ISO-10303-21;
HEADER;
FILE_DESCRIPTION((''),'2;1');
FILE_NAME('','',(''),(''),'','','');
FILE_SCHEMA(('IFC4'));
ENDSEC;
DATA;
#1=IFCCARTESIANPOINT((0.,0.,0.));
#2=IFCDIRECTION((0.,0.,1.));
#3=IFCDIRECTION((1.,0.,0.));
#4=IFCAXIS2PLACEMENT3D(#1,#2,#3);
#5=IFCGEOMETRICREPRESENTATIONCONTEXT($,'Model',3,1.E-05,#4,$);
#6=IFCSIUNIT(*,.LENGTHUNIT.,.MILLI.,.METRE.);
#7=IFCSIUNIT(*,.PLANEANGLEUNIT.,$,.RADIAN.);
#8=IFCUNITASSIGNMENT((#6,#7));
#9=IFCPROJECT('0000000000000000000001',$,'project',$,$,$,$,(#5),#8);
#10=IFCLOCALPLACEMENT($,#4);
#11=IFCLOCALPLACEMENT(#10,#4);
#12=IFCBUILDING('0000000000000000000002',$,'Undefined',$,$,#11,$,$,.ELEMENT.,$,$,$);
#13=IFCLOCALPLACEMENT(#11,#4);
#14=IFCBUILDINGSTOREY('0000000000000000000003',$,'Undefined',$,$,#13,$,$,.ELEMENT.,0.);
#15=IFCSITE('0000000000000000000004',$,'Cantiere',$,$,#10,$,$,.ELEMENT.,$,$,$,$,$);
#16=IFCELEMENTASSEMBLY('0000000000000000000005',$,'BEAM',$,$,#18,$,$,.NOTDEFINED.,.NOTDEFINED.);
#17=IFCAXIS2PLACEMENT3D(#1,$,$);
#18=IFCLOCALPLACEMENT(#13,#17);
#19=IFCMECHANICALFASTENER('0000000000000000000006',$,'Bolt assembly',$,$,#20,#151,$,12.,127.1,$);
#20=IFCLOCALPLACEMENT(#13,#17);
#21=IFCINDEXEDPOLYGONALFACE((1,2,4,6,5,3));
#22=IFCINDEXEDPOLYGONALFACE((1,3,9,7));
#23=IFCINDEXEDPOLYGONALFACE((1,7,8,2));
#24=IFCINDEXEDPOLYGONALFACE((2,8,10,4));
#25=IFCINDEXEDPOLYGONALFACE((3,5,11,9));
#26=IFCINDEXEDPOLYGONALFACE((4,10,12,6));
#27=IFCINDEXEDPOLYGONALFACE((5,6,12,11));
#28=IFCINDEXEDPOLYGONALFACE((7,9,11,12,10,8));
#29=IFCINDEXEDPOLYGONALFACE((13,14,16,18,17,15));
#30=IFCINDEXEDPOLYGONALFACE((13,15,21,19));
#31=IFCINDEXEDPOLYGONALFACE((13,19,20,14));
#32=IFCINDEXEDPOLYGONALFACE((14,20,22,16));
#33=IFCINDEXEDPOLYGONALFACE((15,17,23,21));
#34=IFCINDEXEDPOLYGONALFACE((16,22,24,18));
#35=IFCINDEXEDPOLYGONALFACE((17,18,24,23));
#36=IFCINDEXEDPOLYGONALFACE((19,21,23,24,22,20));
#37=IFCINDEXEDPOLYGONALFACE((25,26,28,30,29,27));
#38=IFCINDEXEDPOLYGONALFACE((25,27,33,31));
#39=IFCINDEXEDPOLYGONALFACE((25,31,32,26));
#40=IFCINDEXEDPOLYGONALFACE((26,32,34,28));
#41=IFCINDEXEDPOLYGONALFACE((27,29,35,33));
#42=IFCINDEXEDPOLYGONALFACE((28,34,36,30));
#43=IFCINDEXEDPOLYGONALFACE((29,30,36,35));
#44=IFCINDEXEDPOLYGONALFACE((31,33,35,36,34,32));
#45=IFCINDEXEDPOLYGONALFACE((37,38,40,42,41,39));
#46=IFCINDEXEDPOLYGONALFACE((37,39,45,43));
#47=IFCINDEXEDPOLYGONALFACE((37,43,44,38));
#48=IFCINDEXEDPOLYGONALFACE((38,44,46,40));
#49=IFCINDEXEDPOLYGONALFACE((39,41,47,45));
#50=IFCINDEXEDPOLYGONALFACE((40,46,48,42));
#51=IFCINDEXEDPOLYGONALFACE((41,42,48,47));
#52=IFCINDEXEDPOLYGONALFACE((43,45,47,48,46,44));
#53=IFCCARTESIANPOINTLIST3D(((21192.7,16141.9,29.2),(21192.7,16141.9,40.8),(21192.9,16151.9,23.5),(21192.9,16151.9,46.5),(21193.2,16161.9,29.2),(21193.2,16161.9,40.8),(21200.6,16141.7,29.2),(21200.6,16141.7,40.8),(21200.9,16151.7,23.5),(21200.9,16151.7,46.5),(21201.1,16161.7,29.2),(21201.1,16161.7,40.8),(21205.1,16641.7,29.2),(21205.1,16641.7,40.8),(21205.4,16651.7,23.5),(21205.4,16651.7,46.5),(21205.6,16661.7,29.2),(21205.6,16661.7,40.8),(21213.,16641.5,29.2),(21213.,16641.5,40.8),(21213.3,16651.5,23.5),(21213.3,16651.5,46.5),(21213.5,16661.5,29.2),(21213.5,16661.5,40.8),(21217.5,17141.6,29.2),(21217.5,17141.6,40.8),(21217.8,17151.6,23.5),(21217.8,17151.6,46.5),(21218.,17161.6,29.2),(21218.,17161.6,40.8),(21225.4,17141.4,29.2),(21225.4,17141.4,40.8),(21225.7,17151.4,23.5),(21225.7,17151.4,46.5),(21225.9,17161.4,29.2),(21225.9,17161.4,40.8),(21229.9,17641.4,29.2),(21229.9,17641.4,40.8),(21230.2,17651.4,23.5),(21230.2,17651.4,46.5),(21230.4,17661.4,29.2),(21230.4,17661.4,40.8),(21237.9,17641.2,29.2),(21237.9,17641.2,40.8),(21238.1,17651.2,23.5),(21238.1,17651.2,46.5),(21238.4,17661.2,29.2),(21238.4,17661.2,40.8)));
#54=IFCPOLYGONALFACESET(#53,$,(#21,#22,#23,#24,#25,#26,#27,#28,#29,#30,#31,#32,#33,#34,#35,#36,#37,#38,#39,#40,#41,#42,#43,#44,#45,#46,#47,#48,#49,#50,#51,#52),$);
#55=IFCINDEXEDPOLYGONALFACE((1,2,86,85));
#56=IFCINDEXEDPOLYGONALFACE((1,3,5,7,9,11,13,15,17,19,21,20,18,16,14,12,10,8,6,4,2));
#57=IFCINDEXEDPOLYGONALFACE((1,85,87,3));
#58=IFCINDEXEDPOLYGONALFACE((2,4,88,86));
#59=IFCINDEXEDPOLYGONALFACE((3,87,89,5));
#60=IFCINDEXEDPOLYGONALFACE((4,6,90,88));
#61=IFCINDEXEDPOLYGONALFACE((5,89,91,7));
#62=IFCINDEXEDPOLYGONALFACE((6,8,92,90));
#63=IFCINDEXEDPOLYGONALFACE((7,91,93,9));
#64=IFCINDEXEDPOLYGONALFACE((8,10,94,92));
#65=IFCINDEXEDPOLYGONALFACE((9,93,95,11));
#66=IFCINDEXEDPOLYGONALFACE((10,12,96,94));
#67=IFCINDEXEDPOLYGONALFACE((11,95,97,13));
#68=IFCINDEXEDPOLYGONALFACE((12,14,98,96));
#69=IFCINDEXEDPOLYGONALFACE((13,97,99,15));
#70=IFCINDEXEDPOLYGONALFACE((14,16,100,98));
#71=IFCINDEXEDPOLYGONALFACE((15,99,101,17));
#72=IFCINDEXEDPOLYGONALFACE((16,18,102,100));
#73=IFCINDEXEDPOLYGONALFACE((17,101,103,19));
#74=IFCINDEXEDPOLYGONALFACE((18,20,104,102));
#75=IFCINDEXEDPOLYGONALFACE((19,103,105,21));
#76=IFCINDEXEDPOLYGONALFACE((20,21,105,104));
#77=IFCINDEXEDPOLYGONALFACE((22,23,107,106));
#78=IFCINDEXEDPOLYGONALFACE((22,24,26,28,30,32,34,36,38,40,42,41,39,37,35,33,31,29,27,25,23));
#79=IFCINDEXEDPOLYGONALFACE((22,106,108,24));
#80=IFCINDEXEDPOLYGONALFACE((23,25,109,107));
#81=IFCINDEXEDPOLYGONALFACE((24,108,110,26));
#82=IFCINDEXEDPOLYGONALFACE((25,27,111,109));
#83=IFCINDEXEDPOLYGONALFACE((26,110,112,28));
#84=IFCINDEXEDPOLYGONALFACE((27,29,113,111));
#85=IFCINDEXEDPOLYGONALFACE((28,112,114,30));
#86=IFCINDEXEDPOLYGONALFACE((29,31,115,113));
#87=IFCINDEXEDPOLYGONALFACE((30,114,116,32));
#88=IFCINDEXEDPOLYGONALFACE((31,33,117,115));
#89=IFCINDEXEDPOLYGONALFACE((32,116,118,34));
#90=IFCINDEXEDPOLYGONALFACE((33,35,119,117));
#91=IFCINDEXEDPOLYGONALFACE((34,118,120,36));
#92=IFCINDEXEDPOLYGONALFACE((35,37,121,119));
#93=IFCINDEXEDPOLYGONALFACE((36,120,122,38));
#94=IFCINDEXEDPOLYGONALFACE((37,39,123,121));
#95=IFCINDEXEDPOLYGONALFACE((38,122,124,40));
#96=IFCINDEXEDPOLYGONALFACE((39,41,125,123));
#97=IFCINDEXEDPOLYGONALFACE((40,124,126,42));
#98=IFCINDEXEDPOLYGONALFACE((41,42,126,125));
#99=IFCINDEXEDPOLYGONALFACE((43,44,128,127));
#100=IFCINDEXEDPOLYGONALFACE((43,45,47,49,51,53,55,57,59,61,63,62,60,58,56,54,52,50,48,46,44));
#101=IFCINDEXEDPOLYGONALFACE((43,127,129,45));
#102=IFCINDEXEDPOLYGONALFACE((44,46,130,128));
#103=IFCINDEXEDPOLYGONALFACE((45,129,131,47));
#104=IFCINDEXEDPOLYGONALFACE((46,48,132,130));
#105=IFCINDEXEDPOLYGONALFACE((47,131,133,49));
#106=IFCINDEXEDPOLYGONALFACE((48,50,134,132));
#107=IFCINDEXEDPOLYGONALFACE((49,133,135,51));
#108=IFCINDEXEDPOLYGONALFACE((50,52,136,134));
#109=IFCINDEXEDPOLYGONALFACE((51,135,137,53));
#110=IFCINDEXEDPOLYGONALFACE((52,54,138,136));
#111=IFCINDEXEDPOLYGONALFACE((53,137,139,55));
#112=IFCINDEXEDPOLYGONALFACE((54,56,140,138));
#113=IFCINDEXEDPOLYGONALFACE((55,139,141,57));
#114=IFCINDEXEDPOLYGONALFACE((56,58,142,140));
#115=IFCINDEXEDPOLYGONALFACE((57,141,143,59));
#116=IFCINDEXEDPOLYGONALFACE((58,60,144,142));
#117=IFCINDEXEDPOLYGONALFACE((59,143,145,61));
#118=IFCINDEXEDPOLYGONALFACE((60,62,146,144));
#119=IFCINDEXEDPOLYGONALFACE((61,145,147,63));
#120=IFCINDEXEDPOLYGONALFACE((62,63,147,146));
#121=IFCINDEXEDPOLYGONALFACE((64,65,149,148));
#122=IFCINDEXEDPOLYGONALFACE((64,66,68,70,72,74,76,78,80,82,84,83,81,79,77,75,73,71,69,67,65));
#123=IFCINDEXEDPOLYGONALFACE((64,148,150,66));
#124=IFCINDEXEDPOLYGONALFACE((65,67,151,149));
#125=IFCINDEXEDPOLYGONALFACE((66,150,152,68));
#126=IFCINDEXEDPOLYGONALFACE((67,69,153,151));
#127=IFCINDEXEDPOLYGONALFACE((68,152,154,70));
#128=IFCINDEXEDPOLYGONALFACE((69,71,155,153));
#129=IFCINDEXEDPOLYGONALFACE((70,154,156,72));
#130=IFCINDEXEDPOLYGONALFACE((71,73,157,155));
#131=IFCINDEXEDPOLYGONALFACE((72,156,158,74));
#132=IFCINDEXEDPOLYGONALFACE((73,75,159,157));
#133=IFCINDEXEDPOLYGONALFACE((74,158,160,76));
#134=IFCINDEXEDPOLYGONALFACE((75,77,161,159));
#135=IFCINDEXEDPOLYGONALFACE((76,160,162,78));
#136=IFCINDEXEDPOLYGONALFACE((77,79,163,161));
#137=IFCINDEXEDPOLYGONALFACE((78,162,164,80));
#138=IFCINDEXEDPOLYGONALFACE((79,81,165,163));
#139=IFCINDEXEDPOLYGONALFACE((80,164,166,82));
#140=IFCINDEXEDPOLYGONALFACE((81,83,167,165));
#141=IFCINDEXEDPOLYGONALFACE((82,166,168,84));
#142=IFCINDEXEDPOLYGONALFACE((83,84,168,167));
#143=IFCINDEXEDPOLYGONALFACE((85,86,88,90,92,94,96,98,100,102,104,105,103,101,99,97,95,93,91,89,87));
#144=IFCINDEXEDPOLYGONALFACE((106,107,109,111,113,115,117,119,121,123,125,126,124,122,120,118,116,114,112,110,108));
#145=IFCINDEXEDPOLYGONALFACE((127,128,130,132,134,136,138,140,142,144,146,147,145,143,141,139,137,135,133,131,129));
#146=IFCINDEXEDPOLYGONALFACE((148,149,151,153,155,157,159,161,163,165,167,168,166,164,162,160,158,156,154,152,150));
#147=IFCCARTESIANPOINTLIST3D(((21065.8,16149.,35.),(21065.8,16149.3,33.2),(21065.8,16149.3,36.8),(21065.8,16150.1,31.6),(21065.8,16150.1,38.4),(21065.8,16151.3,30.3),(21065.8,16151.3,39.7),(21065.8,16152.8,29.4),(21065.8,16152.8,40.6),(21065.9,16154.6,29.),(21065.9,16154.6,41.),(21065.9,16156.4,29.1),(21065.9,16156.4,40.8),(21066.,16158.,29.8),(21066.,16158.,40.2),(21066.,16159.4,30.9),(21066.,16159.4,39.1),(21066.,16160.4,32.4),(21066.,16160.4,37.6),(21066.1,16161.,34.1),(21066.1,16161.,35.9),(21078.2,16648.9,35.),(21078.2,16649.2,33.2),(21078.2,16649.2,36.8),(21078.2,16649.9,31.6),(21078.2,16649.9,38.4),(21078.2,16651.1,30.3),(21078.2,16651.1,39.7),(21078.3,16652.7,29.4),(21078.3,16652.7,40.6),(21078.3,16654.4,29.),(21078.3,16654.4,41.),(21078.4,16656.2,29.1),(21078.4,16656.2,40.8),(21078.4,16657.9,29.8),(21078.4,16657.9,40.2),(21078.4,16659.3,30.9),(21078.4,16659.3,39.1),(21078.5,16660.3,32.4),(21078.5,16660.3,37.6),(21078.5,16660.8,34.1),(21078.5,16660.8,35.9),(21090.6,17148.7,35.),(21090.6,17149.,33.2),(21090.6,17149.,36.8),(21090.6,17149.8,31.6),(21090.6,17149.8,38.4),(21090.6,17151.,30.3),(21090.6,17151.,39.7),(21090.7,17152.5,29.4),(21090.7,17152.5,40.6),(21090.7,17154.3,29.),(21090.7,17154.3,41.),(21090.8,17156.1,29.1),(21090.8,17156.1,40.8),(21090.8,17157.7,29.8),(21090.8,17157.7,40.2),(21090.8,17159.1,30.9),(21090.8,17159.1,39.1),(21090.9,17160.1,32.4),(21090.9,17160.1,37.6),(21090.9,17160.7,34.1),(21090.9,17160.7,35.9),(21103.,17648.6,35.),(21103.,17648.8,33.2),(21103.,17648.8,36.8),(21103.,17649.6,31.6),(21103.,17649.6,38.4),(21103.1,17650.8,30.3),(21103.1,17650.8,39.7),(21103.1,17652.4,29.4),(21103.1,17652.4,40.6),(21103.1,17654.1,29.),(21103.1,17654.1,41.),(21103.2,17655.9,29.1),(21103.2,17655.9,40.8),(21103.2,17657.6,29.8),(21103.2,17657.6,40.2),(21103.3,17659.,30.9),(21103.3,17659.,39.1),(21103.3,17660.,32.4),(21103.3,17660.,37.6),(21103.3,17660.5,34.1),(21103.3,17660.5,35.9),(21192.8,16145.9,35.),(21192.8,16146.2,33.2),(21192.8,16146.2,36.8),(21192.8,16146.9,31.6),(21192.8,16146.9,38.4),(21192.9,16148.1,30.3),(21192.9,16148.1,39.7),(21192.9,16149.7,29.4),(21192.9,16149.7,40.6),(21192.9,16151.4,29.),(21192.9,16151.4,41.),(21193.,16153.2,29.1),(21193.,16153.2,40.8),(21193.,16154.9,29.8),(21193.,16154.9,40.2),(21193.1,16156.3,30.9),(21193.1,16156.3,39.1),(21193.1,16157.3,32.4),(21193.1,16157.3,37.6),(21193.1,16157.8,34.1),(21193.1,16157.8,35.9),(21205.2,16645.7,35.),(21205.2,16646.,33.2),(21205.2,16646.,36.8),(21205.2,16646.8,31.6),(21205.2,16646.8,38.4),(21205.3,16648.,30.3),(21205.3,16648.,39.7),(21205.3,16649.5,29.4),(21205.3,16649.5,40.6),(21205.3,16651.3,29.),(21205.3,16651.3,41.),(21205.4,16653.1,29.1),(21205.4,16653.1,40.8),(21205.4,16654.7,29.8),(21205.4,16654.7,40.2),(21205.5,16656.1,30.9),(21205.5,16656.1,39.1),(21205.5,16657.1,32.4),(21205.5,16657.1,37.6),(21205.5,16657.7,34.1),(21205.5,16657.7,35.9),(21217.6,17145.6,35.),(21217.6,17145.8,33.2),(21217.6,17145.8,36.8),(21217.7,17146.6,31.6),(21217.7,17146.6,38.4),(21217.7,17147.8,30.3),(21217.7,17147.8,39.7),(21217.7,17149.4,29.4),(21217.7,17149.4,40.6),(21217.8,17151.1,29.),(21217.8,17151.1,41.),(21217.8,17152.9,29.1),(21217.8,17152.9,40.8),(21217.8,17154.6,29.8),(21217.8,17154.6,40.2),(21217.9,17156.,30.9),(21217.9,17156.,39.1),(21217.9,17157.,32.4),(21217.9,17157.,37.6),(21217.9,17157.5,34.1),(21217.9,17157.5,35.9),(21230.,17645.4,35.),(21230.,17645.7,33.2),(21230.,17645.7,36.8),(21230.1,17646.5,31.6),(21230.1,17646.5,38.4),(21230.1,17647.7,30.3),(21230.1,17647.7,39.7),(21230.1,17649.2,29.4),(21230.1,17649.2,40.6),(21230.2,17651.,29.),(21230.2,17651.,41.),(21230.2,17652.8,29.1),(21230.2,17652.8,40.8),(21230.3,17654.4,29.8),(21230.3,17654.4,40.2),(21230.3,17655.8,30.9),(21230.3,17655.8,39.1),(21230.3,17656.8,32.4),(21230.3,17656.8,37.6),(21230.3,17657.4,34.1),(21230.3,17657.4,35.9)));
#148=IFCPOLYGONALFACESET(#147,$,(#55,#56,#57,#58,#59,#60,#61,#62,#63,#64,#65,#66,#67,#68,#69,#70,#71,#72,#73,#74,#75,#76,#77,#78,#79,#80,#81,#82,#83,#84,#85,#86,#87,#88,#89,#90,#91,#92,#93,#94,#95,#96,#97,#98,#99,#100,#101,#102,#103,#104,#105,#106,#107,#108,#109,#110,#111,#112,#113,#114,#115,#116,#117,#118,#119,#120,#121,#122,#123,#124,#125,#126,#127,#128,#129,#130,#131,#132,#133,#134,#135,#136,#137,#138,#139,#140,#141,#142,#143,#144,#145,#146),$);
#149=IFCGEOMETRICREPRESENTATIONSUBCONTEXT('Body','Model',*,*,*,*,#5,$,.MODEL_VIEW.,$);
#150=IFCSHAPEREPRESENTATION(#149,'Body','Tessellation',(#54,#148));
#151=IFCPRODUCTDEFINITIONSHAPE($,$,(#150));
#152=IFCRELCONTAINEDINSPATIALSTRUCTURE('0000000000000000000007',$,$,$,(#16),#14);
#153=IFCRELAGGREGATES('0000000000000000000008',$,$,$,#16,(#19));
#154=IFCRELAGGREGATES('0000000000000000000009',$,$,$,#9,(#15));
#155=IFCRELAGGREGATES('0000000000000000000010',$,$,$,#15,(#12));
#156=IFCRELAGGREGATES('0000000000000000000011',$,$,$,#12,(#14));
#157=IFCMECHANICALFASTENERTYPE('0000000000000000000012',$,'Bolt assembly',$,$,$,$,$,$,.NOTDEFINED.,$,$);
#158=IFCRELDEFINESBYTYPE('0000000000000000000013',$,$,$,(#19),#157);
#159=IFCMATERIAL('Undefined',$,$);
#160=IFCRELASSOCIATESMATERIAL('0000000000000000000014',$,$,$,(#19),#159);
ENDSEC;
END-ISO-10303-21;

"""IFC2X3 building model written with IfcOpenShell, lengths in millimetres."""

from ifc_helpers import new_model, si_unit, frame, origin_with_axes, origin_2d_with_axis, place, context, subcontext, project, spatial, polyline, circle, outline, extrude, source, transform, mapped, material, type_object, element, aggregate, save


model = new_model("IFC2X3")

# Units and contexts
model_context = context("Model", 3, precision=1e-05, world=origin_with_axes())
body_context = subcontext(model_context, "Body", "Model", "MODEL_VIEW")
ifc_project = project(units=[si_unit("LENGTHUNIT", "METRE", prefix="MILLI"), si_unit("PLANEANGLEUNIT", "RADIAN")], contexts=[model_context])

# Site, building, storey
site_placement = place(None, origin_with_axes())
site = spatial("IfcSite", under=ifc_project, at=site_placement, Name="Cantiere", CompositionType="ELEMENT")
building_placement = place(site_placement, origin_with_axes())
building = spatial("IfcBuilding", under=site, at=building_placement, Name="Undefined", CompositionType="ELEMENT")
storey_placement = place(building_placement, origin_with_axes())
storey = spatial("IfcBuildingStorey", under=building, at=storey_placement, Name="Undefined", CompositionType="ELEMENT", Elevation=0.0)

# Shared definitions
mechanical_fastener_type = type_object("IfcMechanicalFastenerType", Name="Bolt assembly")

# Element assembly, mechanical fastener
ifc_material_1 = material(Name="Undefined")
shared_shape_1 = source(origin_with_axes(), body_context, "Body", "SweptSolid", [
    extrude(outline(polyline([(10.0, -5.8), (10.0, 5.8), (0.0, 11.5), (-10.0, 5.8), (-10.0, -5.8), (0.0, -11.5), (10.0, -5.8)])), frame((0.0, -135.0, 0.0), z_axis=(0.0, 1.0, 0.0), x_axis=(1.0, 0.0, 0.0)), (0.0, 0.0, 1.0), 7.9),
    extrude(circle(Radius=6.0, at=origin_2d_with_axis()), frame((0.0, -127.1, 0.0), z_axis=(0.0, 1.0, 0.0), x_axis=(1.0, 0.0, 0.0)), (0.0, 0.0, 1.0), 127.1),
])
assembly_1_placement = place(storey_placement, origin_with_axes())
assembly_1 = element("IfcElementAssembly", 1, at=assembly_1_placement, inside=storey, Name="BEAM", AssemblyPlace="NOTDEFINED", PredefinedType="NOTDEFINED")
mechanical_fastener_1_placement = place(assembly_1_placement, frame((21103.1, 17654.6, 35.0), z_axis=(0.0, 0.000001, -1.0), x_axis=(-0.02483, -0.999692, 0.0)))
mechanical_fastener_1 = element("IfcMechanicalFastener", 2, at=mechanical_fastener_1_placement, type_object=mechanical_fastener_type, material=ifc_material_1, Name="Bolt assembly", NominalDiameter=12.0, NominalLength=127.1, context=body_context, shape_type="MappedRepresentation", body=[
    mapped(shared_shape_1, transform((0.0, 0.0, 0.0))),
    mapped(shared_shape_1, transform((500.0, 0.0, 0.0))),
    mapped(shared_shape_1, transform((1000.0, 0.0, 0.0))),
    mapped(shared_shape_1, transform((1500.0, 0.0, 0.0))),
])
aggregate(assembly_1, [mechanical_fastener_1])

save(model, "model.ifc")
